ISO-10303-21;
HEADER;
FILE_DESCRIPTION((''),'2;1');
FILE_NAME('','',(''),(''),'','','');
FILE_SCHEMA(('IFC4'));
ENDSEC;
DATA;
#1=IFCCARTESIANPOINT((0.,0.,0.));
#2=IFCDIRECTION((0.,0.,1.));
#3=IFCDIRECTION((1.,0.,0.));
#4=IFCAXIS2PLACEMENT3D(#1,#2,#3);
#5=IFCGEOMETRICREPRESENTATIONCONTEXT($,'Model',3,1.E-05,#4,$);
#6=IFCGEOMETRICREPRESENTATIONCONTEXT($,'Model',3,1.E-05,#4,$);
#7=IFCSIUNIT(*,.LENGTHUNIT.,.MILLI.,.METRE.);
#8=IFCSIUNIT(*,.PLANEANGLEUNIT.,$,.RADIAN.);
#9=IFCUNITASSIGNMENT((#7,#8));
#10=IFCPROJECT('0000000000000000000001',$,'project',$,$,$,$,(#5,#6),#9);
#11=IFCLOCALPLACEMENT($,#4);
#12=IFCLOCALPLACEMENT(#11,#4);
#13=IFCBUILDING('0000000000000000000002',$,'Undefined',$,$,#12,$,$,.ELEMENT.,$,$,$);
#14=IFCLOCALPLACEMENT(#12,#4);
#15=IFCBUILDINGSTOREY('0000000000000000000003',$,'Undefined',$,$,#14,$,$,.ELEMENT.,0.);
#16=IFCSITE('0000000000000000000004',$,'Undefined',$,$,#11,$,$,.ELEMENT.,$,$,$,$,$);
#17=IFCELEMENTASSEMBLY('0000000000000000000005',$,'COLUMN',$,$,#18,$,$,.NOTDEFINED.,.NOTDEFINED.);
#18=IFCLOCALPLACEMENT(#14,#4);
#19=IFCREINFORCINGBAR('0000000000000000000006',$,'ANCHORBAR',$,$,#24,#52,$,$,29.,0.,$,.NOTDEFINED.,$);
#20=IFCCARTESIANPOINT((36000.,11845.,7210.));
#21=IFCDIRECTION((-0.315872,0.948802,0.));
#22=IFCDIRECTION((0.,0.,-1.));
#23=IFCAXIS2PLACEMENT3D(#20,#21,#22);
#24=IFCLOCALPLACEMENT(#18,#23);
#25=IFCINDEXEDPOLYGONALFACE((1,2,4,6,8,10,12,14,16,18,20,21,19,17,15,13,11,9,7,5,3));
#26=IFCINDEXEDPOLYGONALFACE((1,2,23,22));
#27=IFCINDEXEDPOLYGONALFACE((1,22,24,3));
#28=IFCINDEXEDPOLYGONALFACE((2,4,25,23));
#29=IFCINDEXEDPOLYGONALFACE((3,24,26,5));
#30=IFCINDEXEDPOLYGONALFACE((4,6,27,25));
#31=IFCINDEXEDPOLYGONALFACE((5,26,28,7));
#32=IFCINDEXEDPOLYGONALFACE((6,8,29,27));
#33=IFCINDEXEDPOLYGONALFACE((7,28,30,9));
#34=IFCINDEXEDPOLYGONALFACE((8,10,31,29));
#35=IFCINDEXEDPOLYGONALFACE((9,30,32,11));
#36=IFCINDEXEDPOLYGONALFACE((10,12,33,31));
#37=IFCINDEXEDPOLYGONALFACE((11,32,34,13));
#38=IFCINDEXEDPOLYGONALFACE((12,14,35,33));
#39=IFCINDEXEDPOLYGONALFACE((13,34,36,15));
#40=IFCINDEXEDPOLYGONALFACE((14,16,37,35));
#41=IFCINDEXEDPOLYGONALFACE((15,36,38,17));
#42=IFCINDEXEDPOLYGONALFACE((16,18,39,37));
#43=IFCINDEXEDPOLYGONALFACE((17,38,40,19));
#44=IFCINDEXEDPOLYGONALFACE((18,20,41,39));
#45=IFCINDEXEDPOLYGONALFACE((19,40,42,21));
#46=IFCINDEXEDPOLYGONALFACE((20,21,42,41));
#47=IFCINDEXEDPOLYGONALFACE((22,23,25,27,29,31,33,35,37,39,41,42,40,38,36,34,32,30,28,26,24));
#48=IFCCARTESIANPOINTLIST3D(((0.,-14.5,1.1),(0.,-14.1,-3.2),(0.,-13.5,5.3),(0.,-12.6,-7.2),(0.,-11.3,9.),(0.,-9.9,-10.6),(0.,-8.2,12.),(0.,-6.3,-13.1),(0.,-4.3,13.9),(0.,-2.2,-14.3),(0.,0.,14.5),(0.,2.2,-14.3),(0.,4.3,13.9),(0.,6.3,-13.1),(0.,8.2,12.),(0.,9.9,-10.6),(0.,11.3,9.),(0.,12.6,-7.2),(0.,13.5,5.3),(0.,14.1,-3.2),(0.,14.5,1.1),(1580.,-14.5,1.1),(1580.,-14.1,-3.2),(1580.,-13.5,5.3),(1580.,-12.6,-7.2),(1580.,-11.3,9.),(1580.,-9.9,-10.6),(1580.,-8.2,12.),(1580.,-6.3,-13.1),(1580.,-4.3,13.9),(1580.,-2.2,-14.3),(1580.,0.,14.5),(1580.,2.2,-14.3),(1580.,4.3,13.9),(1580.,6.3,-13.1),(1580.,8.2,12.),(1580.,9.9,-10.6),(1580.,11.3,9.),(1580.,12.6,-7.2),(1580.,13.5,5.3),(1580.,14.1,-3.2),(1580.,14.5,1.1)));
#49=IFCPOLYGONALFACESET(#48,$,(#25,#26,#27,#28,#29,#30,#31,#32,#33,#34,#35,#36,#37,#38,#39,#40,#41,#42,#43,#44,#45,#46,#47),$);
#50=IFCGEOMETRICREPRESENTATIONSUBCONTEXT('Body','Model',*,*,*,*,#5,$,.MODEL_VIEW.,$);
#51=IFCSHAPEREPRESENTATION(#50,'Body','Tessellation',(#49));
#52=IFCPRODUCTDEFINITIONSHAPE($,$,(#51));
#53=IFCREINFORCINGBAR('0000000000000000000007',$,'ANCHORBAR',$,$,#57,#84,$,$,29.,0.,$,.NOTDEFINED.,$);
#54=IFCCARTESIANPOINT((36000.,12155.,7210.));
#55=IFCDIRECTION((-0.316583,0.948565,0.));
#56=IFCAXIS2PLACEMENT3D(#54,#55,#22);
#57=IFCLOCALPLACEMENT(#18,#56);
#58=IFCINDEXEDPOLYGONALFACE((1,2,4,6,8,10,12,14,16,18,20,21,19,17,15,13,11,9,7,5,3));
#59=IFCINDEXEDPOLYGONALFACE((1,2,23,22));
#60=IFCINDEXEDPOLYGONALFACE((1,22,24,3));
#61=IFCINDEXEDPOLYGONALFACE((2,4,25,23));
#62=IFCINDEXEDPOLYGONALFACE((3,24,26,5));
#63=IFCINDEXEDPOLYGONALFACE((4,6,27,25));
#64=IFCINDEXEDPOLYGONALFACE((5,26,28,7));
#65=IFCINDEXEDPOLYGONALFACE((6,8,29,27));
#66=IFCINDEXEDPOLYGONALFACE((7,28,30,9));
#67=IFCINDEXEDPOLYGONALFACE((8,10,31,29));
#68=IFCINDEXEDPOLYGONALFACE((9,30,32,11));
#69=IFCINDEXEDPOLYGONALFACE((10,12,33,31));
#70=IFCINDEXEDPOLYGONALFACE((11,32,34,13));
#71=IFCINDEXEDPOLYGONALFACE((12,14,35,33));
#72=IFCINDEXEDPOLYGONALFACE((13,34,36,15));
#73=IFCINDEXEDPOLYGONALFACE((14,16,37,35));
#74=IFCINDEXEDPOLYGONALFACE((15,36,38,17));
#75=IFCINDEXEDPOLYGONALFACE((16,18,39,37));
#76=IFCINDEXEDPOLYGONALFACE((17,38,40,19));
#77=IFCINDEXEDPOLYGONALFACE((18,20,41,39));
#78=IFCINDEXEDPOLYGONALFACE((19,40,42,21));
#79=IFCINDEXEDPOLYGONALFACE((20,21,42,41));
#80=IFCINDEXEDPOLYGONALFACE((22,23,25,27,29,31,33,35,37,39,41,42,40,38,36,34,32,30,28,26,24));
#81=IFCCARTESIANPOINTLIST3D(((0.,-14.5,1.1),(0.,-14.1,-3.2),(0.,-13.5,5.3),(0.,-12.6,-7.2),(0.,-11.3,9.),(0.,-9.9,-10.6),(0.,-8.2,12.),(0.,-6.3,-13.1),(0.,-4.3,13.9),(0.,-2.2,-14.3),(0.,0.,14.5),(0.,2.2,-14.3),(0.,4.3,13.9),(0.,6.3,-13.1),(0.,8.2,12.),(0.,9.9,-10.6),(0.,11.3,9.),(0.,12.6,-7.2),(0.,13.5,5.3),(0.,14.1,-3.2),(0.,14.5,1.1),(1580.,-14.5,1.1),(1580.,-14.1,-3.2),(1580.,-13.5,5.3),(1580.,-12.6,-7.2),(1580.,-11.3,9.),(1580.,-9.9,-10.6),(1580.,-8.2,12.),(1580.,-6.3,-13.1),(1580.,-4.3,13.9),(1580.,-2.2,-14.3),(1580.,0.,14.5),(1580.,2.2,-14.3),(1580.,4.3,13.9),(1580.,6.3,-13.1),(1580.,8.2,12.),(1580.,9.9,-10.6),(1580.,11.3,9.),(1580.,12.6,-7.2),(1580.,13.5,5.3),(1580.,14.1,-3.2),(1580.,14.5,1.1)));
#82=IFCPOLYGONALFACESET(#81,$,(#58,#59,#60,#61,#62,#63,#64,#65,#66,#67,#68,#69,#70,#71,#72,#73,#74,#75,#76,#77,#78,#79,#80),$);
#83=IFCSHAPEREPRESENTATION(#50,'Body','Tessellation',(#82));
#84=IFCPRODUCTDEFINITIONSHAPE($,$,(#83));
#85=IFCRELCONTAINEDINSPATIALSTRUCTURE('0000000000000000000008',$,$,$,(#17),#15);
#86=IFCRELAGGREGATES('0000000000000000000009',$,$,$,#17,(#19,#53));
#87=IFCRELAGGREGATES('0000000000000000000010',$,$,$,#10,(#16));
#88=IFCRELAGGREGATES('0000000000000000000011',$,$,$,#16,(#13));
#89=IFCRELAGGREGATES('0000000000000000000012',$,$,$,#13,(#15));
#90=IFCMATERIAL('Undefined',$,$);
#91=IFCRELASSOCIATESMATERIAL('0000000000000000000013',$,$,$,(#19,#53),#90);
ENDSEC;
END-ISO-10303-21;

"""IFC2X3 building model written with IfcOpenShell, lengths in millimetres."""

from ifc_helpers import new_model, entity, si_unit, frame, origin_with_axes, place, context, subcontext, project, spatial, source, transform, mapped, material, element, aggregate, save


model = new_model("IFC2X3")

# Units and contexts
model_context_1 = context("Model", 3, precision=1e-05, world=origin_with_axes())
model_context_2 = context("Model", 3, precision=1e-05, world=origin_with_axes())
body_context = subcontext(model_context_1, "Body", "Model", "MODEL_VIEW")
ifc_project = project(units=[si_unit("LENGTHUNIT", "METRE", prefix="MILLI"), si_unit("PLANEANGLEUNIT", "RADIAN")], contexts=[model_context_1, model_context_2])

# Site, building, storey
site_placement = place(None, origin_with_axes())
site = spatial("IfcSite", under=ifc_project, at=site_placement, Name="Undefined", CompositionType="ELEMENT")
building_placement = place(site_placement, origin_with_axes())
building = spatial("IfcBuilding", under=site, at=building_placement, Name="Undefined", CompositionType="ELEMENT")
storey_placement = place(building_placement, origin_with_axes())
storey = spatial("IfcBuildingStorey", under=building, at=storey_placement, Name="Undefined", CompositionType="ELEMENT", Elevation=0.0)

# Element assembly
assembly_1_placement = place(storey_placement, origin_with_axes())
assembly_1 = element("IfcElementAssembly", 1, at=assembly_1_placement, inside=storey, Name="COLUMN", AssemblyPlace="NOTDEFINED", PredefinedType="NOTDEFINED")

# Reinforcing bars
ifc_material_1 = material(Name="Undefined")
shared_shape_1 = source(origin_with_axes(), body_context, "Body", "AdvancedSweptSolid", [
    entity("IfcSweptDiskSolid", entity("IfcTrimmedCurve", entity("IfcLine", entity("IfcCartesianPoint", [0.0, 0.0, 0.0]), entity("IfcVector", entity("IfcDirection", [1.0, 0.0, 0.0]), 1.0)), [entity("IfcParameterValue", 0.0)], [entity("IfcParameterValue", 1580.0)], True, "PARAMETER"), 14.5, None, 0.0, 1580.0),
])
reinforcing_bar_1_placement = place(assembly_1_placement, frame((36000.0, 11845.0, 7210.0), z_axis=(-0.315872, 0.948802, 0.0), x_axis=(0.0, 0.0, -1.0)))
reinforcing_bar_1 = element("IfcReinforcingBar", 2, at=reinforcing_bar_1_placement, material=ifc_material_1, Name="ANCHORBAR", BarRole="NOTDEFINED", CrossSectionArea=0.0, NominalDiameter=29.0, context=body_context, shape_type="MappedRepresentation", body=[
    mapped(shared_shape_1, transform((0.0, 0.0, 0.0))),
])
shared_shape_2 = source(origin_with_axes(), body_context, "Body", "AdvancedSweptSolid", [
    entity("IfcSweptDiskSolid", entity("IfcTrimmedCurve", entity("IfcLine", entity("IfcCartesianPoint", [0.0, 0.0, 0.0]), entity("IfcVector", entity("IfcDirection", [1.0, 0.0, 0.0]), 1.0)), [entity("IfcParameterValue", 0.0)], [entity("IfcParameterValue", 1580.0)], True, "PARAMETER"), 14.5, None, 0.0, 1580.0),
])
reinforcing_bar_2_placement = place(assembly_1_placement, frame((36000.0, 12155.0, 7210.0), z_axis=(-0.316583, 0.948565, 0.0), x_axis=(0.0, 0.0, -1.0)))
reinforcing_bar_2 = element("IfcReinforcingBar", 3, at=reinforcing_bar_2_placement, material=ifc_material_1, Name="ANCHORBAR", BarRole="NOTDEFINED", CrossSectionArea=0.0, NominalDiameter=29.0, context=body_context, shape_type="MappedRepresentation", body=[
    mapped(shared_shape_2, transform((0.0, 0.0, 0.0))),
])
aggregate(assembly_1, [reinforcing_bar_1, reinforcing_bar_2])

save(model, "model.ifc")
